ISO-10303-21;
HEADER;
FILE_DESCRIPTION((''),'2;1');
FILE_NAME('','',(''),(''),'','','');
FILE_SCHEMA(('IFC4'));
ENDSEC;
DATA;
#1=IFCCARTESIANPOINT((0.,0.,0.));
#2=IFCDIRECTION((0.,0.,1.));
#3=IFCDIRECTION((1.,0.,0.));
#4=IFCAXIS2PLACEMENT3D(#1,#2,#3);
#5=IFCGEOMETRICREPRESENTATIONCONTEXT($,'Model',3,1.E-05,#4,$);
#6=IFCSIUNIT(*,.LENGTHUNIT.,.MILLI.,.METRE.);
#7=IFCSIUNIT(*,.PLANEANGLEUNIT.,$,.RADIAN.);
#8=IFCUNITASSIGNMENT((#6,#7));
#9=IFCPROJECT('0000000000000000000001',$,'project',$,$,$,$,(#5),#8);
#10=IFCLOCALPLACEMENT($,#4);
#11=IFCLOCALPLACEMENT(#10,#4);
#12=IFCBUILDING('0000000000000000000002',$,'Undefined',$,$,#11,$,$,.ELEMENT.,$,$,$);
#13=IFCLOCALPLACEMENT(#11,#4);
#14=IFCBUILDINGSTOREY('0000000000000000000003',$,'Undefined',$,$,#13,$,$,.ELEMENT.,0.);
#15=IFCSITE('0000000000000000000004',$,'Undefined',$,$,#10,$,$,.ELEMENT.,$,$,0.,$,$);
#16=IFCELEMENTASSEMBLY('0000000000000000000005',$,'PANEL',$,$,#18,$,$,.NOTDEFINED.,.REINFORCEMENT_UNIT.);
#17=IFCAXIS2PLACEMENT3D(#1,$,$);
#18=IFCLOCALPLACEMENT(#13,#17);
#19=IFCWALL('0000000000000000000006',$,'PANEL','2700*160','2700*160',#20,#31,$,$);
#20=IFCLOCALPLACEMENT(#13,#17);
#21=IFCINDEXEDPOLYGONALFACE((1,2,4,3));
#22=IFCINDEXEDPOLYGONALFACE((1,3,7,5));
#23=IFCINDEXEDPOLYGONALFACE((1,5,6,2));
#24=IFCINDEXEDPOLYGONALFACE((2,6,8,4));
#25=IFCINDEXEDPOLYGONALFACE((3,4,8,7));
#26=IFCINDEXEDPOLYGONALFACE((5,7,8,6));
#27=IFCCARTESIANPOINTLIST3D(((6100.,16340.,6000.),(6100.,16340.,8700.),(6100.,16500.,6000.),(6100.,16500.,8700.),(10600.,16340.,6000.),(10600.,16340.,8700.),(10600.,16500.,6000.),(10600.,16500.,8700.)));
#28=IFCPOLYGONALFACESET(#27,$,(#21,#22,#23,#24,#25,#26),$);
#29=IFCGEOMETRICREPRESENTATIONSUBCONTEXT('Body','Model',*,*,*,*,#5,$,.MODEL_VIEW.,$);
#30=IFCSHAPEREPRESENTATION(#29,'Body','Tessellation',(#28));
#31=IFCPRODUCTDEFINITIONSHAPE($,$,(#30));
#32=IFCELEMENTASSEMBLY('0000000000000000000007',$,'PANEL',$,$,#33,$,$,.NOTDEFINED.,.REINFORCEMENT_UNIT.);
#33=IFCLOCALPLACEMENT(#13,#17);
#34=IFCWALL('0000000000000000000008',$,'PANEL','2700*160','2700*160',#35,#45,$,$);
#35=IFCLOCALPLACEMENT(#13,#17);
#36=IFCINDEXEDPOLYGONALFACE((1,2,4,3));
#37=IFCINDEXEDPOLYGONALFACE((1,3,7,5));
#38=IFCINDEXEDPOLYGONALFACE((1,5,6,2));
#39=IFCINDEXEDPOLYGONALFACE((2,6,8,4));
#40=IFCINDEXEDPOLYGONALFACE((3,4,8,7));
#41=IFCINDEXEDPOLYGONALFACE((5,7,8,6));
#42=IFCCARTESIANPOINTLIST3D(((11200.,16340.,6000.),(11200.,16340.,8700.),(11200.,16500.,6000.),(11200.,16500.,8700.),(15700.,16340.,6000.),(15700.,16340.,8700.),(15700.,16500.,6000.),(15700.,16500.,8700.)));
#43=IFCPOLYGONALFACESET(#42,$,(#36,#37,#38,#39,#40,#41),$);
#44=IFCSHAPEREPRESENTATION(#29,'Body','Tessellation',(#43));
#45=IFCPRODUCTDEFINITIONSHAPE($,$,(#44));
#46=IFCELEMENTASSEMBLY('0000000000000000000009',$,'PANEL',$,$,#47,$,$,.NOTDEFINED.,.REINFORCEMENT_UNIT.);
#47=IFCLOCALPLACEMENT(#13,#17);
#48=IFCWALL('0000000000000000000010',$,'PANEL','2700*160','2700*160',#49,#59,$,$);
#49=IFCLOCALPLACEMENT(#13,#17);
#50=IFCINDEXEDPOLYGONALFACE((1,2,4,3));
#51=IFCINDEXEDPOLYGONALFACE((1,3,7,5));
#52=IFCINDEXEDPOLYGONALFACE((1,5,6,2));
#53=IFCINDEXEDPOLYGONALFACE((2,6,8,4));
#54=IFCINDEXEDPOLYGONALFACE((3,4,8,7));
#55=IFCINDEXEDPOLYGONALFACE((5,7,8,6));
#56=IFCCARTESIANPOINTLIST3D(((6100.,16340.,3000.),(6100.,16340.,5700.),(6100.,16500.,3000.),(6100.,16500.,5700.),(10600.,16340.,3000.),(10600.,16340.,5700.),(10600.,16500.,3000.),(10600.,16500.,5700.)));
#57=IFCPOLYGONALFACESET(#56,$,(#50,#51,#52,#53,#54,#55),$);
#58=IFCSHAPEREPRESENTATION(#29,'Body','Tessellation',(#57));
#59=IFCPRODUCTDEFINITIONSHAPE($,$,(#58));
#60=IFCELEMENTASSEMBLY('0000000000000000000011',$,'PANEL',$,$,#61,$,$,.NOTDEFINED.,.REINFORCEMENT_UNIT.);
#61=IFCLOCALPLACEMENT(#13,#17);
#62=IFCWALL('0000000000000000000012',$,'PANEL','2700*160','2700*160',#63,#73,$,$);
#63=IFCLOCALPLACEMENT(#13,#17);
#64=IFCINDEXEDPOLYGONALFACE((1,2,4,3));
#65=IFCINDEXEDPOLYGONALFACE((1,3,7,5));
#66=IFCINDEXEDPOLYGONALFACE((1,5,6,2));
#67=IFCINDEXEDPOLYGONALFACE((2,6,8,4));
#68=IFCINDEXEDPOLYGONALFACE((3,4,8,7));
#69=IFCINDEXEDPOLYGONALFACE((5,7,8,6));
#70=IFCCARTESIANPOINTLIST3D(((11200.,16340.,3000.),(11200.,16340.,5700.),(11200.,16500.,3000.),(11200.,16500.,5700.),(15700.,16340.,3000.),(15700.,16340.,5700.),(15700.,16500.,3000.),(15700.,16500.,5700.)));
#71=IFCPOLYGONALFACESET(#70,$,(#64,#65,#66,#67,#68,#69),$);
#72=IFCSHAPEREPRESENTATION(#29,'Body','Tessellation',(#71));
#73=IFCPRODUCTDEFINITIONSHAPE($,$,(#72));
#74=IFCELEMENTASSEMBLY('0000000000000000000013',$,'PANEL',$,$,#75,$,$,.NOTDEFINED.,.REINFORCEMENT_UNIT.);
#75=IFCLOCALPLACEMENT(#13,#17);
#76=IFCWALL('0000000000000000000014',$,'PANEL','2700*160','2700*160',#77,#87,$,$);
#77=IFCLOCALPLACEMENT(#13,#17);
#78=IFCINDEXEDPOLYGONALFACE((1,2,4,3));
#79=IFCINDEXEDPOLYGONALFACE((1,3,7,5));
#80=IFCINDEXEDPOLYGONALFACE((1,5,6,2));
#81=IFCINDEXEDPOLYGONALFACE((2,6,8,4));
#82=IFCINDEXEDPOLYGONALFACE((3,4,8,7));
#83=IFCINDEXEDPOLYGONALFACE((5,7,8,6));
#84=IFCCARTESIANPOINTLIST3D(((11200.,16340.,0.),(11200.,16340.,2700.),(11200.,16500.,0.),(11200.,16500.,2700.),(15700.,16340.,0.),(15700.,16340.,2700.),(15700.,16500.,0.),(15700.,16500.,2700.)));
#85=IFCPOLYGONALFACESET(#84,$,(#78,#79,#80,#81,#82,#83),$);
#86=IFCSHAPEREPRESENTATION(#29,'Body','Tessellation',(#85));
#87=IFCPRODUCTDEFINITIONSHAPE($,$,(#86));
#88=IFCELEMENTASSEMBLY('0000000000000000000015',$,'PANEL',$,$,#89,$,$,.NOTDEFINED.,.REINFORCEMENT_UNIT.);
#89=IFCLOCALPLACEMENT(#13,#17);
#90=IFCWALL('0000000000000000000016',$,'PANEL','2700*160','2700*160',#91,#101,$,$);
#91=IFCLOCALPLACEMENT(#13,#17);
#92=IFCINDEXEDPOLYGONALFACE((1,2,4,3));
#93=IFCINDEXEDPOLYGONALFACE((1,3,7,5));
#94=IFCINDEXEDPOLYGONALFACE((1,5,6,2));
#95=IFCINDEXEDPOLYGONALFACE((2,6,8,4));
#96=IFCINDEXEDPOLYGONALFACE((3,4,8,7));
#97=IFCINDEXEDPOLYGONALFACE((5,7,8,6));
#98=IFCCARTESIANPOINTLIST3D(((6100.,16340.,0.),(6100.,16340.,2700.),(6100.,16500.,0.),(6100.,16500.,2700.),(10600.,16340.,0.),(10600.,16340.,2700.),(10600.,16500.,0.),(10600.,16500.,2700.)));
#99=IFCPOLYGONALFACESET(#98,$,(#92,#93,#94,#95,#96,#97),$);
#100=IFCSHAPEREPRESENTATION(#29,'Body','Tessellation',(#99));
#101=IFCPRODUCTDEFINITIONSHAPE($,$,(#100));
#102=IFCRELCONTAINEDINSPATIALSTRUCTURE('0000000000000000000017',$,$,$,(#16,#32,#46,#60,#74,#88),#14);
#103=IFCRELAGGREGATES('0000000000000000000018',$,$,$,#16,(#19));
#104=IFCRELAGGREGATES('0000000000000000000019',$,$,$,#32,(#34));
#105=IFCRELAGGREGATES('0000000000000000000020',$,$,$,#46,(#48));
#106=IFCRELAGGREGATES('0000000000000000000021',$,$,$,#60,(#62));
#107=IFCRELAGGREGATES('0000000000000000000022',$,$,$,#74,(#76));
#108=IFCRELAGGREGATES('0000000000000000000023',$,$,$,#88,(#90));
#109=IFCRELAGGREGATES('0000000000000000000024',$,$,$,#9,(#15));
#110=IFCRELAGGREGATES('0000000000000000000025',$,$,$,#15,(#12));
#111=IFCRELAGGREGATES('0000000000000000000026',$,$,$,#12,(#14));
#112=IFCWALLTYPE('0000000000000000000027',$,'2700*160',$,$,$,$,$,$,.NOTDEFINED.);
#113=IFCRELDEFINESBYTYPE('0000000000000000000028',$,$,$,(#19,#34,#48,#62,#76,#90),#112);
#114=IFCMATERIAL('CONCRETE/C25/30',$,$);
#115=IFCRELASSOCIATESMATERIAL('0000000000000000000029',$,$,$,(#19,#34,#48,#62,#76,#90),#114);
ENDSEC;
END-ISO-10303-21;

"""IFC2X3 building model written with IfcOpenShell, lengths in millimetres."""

from ifc_helpers import new_model, si_unit, frame, frame_2d, origin_with_axes, place, context, subcontext, project, spatial, rectangle, extrude, material, type_object, element, aggregate, save


model = new_model("IFC2X3")

# Units and contexts
model_context = context("Model", 3, precision=1e-05, world=origin_with_axes())
body_context = subcontext(model_context, "Body", "Model", "MODEL_VIEW")
ifc_project = project(units=[si_unit("LENGTHUNIT", "METRE", prefix="MILLI"), si_unit("PLANEANGLEUNIT", "RADIAN")], contexts=[model_context])

# Site, building, storey
site_placement = place(None, origin_with_axes())
site = spatial("IfcSite", under=ifc_project, at=site_placement, Name="Undefined", CompositionType="ELEMENT", RefElevation=0.0)
building_placement = place(site_placement, origin_with_axes())
building = spatial("IfcBuilding", under=site, at=building_placement, Name="Undefined", CompositionType="ELEMENT")
storey_placement = place(building_placement, origin_with_axes())
storey = spatial("IfcBuildingStorey", under=building, at=storey_placement, Name="Undefined", CompositionType="ELEMENT", Elevation=0.0)

# Shared definitions
ifc_material = material(Name="CONCRETE/C25/30")

# Element assemblies, walls
assembly_1_placement = place(storey_placement, origin_with_axes())
assembly_1 = element("IfcElementAssembly", 1, at=assembly_1_placement, inside=storey, Name="PANEL", AssemblyPlace="NOTDEFINED", PredefinedType="REINFORCEMENT_UNIT")
wall_type = type_object("IfcWallType", Name="2700*160", PredefinedType="NOTDEFINED")
wall_1_placement = place(assembly_1_placement, frame((6100.0, 16420.0, 6000.0), z_axis=(0.0, 0.0, 1.0), x_axis=(1.0, 0.0, 0.0)))
wall_1 = element("IfcWall", 2, at=wall_1_placement, type_object=wall_type, material=ifc_material, Name="PANEL", Description="2700*160", ObjectType="2700*160", context=body_context, shape_type="SweptSolid", body=[
    extrude(rectangle(XDim=4500.0, YDim=160.0, at=frame_2d((0.0, 2250.0), x_axis=(0.0, -1.0))), frame((0.0, 0.0, 0.0), z_axis=(0.0, 0.0, 1.0), x_axis=(0.0, -1.0, 0.0)), (0.0, 0.0, 1.0), 2700.0),
])
aggregate(assembly_1, [wall_1])
assembly_2_placement = place(storey_placement, origin_with_axes())
assembly_2 = element("IfcElementAssembly", 3, at=assembly_2_placement, inside=storey, Name="PANEL", AssemblyPlace="NOTDEFINED", PredefinedType="REINFORCEMENT_UNIT")
wall_2_placement = place(assembly_2_placement, frame((11200.0, 16420.0, 6000.0), z_axis=(0.0, 0.0, 1.0), x_axis=(1.0, 0.0, 0.0)))
wall_2 = element("IfcWall", 4, at=wall_2_placement, type_object=wall_type, material=ifc_material, Name="PANEL", Description="2700*160", ObjectType="2700*160", context=body_context, shape_type="SweptSolid", body=[
    extrude(rectangle(XDim=4500.0, YDim=160.0, at=frame_2d((0.0, 2250.0), x_axis=(0.0, -1.0))), frame((0.0, 0.0, 0.0), z_axis=(0.0, 0.0, 1.0), x_axis=(0.0, -1.0, 0.0)), (0.0, 0.0, 1.0), 2700.0),
])
aggregate(assembly_2, [wall_2])
assembly_3_placement = place(storey_placement, origin_with_axes())
assembly_3 = element("IfcElementAssembly", 5, at=assembly_3_placement, inside=storey, Name="PANEL", AssemblyPlace="NOTDEFINED", PredefinedType="REINFORCEMENT_UNIT")
wall_3_placement = place(assembly_3_placement, frame((6100.0, 16420.0, 3000.0), z_axis=(0.0, 0.0, 1.0), x_axis=(1.0, 0.0, 0.0)))
wall_3 = element("IfcWall", 6, at=wall_3_placement, type_object=wall_type, material=ifc_material, Name="PANEL", Description="2700*160", ObjectType="2700*160", context=body_context, shape_type="SweptSolid", body=[
    extrude(rectangle(XDim=4500.0, YDim=160.0, at=frame_2d((0.0, 2250.0), x_axis=(0.0, -1.0))), frame((0.0, 0.0, 0.0), z_axis=(0.0, 0.0, 1.0), x_axis=(0.0, -1.0, 0.0)), (0.0, 0.0, 1.0), 2700.0),
])
aggregate(assembly_3, [wall_3])
assembly_4_placement = place(storey_placement, origin_with_axes())
assembly_4 = element("IfcElementAssembly", 7, at=assembly_4_placement, inside=storey, Name="PANEL", AssemblyPlace="NOTDEFINED", PredefinedType="REINFORCEMENT_UNIT")
wall_4_placement = place(assembly_4_placement, frame((11200.0, 16420.0, 3000.0), z_axis=(0.0, 0.0, 1.0), x_axis=(1.0, 0.0, 0.0)))
wall_4 = element("IfcWall", 8, at=wall_4_placement, type_object=wall_type, material=ifc_material, Name="PANEL", Description="2700*160", ObjectType="2700*160", context=body_context, shape_type="SweptSolid", body=[
    extrude(rectangle(XDim=4500.0, YDim=160.0, at=frame_2d((0.0, 2250.0), x_axis=(0.0, -1.0))), frame((0.0, 0.0, 0.0), z_axis=(0.0, 0.0, 1.0), x_axis=(0.0, -1.0, 0.0)), (0.0, 0.0, 1.0), 2700.0),
])
aggregate(assembly_4, [wall_4])
assembly_5_placement = place(storey_placement, origin_with_axes())
assembly_5 = element("IfcElementAssembly", 9, at=assembly_5_placement, inside=storey, Name="PANEL", AssemblyPlace="NOTDEFINED", PredefinedType="REINFORCEMENT_UNIT")
wall_5_placement = place(assembly_5_placement, frame((15700.0, 16420.0, 0.0), z_axis=(0.0, 0.0, 1.0), x_axis=(-1.0, 0.0, 0.0)))
wall_5 = element("IfcWall", 10, at=wall_5_placement, type_object=wall_type, material=ifc_material, Name="PANEL", Description="2700*160", ObjectType="2700*160", context=body_context, shape_type="SweptSolid", body=[
    extrude(rectangle(XDim=4500.0, YDim=160.0, at=frame_2d((0.0, 2250.0), x_axis=(0.0, -1.0))), frame((0.0, 0.0, 0.0), z_axis=(0.0, 0.0, 1.0), x_axis=(0.0, -1.0, 0.0)), (0.0, 0.0, 1.0), 2700.0),
])
aggregate(assembly_5, [wall_5])
assembly_6_placement = place(storey_placement, origin_with_axes())
assembly_6 = element("IfcElementAssembly", 11, at=assembly_6_placement, inside=storey, Name="PANEL", AssemblyPlace="NOTDEFINED", PredefinedType="REINFORCEMENT_UNIT")
wall_6_placement = place(assembly_6_placement, frame((6100.0, 16420.0, 0.0), z_axis=(0.0, 0.0, 1.0), x_axis=(1.0, 0.0, 0.0)))
wall_6 = element("IfcWall", 12, at=wall_6_placement, type_object=wall_type, material=ifc_material, Name="PANEL", Description="2700*160", ObjectType="2700*160", context=body_context, shape_type="SweptSolid", body=[
    extrude(rectangle(XDim=4500.0, YDim=160.0, at=frame_2d((0.0, 2250.0), x_axis=(0.0, -1.0))), frame((0.0, 0.0, 0.0), z_axis=(0.0, 0.0, 1.0), x_axis=(0.0, -1.0, 0.0)), (0.0, 0.0, 1.0), 2700.0),
])
aggregate(assembly_6, [wall_6])

save(model, "model.ifc")
